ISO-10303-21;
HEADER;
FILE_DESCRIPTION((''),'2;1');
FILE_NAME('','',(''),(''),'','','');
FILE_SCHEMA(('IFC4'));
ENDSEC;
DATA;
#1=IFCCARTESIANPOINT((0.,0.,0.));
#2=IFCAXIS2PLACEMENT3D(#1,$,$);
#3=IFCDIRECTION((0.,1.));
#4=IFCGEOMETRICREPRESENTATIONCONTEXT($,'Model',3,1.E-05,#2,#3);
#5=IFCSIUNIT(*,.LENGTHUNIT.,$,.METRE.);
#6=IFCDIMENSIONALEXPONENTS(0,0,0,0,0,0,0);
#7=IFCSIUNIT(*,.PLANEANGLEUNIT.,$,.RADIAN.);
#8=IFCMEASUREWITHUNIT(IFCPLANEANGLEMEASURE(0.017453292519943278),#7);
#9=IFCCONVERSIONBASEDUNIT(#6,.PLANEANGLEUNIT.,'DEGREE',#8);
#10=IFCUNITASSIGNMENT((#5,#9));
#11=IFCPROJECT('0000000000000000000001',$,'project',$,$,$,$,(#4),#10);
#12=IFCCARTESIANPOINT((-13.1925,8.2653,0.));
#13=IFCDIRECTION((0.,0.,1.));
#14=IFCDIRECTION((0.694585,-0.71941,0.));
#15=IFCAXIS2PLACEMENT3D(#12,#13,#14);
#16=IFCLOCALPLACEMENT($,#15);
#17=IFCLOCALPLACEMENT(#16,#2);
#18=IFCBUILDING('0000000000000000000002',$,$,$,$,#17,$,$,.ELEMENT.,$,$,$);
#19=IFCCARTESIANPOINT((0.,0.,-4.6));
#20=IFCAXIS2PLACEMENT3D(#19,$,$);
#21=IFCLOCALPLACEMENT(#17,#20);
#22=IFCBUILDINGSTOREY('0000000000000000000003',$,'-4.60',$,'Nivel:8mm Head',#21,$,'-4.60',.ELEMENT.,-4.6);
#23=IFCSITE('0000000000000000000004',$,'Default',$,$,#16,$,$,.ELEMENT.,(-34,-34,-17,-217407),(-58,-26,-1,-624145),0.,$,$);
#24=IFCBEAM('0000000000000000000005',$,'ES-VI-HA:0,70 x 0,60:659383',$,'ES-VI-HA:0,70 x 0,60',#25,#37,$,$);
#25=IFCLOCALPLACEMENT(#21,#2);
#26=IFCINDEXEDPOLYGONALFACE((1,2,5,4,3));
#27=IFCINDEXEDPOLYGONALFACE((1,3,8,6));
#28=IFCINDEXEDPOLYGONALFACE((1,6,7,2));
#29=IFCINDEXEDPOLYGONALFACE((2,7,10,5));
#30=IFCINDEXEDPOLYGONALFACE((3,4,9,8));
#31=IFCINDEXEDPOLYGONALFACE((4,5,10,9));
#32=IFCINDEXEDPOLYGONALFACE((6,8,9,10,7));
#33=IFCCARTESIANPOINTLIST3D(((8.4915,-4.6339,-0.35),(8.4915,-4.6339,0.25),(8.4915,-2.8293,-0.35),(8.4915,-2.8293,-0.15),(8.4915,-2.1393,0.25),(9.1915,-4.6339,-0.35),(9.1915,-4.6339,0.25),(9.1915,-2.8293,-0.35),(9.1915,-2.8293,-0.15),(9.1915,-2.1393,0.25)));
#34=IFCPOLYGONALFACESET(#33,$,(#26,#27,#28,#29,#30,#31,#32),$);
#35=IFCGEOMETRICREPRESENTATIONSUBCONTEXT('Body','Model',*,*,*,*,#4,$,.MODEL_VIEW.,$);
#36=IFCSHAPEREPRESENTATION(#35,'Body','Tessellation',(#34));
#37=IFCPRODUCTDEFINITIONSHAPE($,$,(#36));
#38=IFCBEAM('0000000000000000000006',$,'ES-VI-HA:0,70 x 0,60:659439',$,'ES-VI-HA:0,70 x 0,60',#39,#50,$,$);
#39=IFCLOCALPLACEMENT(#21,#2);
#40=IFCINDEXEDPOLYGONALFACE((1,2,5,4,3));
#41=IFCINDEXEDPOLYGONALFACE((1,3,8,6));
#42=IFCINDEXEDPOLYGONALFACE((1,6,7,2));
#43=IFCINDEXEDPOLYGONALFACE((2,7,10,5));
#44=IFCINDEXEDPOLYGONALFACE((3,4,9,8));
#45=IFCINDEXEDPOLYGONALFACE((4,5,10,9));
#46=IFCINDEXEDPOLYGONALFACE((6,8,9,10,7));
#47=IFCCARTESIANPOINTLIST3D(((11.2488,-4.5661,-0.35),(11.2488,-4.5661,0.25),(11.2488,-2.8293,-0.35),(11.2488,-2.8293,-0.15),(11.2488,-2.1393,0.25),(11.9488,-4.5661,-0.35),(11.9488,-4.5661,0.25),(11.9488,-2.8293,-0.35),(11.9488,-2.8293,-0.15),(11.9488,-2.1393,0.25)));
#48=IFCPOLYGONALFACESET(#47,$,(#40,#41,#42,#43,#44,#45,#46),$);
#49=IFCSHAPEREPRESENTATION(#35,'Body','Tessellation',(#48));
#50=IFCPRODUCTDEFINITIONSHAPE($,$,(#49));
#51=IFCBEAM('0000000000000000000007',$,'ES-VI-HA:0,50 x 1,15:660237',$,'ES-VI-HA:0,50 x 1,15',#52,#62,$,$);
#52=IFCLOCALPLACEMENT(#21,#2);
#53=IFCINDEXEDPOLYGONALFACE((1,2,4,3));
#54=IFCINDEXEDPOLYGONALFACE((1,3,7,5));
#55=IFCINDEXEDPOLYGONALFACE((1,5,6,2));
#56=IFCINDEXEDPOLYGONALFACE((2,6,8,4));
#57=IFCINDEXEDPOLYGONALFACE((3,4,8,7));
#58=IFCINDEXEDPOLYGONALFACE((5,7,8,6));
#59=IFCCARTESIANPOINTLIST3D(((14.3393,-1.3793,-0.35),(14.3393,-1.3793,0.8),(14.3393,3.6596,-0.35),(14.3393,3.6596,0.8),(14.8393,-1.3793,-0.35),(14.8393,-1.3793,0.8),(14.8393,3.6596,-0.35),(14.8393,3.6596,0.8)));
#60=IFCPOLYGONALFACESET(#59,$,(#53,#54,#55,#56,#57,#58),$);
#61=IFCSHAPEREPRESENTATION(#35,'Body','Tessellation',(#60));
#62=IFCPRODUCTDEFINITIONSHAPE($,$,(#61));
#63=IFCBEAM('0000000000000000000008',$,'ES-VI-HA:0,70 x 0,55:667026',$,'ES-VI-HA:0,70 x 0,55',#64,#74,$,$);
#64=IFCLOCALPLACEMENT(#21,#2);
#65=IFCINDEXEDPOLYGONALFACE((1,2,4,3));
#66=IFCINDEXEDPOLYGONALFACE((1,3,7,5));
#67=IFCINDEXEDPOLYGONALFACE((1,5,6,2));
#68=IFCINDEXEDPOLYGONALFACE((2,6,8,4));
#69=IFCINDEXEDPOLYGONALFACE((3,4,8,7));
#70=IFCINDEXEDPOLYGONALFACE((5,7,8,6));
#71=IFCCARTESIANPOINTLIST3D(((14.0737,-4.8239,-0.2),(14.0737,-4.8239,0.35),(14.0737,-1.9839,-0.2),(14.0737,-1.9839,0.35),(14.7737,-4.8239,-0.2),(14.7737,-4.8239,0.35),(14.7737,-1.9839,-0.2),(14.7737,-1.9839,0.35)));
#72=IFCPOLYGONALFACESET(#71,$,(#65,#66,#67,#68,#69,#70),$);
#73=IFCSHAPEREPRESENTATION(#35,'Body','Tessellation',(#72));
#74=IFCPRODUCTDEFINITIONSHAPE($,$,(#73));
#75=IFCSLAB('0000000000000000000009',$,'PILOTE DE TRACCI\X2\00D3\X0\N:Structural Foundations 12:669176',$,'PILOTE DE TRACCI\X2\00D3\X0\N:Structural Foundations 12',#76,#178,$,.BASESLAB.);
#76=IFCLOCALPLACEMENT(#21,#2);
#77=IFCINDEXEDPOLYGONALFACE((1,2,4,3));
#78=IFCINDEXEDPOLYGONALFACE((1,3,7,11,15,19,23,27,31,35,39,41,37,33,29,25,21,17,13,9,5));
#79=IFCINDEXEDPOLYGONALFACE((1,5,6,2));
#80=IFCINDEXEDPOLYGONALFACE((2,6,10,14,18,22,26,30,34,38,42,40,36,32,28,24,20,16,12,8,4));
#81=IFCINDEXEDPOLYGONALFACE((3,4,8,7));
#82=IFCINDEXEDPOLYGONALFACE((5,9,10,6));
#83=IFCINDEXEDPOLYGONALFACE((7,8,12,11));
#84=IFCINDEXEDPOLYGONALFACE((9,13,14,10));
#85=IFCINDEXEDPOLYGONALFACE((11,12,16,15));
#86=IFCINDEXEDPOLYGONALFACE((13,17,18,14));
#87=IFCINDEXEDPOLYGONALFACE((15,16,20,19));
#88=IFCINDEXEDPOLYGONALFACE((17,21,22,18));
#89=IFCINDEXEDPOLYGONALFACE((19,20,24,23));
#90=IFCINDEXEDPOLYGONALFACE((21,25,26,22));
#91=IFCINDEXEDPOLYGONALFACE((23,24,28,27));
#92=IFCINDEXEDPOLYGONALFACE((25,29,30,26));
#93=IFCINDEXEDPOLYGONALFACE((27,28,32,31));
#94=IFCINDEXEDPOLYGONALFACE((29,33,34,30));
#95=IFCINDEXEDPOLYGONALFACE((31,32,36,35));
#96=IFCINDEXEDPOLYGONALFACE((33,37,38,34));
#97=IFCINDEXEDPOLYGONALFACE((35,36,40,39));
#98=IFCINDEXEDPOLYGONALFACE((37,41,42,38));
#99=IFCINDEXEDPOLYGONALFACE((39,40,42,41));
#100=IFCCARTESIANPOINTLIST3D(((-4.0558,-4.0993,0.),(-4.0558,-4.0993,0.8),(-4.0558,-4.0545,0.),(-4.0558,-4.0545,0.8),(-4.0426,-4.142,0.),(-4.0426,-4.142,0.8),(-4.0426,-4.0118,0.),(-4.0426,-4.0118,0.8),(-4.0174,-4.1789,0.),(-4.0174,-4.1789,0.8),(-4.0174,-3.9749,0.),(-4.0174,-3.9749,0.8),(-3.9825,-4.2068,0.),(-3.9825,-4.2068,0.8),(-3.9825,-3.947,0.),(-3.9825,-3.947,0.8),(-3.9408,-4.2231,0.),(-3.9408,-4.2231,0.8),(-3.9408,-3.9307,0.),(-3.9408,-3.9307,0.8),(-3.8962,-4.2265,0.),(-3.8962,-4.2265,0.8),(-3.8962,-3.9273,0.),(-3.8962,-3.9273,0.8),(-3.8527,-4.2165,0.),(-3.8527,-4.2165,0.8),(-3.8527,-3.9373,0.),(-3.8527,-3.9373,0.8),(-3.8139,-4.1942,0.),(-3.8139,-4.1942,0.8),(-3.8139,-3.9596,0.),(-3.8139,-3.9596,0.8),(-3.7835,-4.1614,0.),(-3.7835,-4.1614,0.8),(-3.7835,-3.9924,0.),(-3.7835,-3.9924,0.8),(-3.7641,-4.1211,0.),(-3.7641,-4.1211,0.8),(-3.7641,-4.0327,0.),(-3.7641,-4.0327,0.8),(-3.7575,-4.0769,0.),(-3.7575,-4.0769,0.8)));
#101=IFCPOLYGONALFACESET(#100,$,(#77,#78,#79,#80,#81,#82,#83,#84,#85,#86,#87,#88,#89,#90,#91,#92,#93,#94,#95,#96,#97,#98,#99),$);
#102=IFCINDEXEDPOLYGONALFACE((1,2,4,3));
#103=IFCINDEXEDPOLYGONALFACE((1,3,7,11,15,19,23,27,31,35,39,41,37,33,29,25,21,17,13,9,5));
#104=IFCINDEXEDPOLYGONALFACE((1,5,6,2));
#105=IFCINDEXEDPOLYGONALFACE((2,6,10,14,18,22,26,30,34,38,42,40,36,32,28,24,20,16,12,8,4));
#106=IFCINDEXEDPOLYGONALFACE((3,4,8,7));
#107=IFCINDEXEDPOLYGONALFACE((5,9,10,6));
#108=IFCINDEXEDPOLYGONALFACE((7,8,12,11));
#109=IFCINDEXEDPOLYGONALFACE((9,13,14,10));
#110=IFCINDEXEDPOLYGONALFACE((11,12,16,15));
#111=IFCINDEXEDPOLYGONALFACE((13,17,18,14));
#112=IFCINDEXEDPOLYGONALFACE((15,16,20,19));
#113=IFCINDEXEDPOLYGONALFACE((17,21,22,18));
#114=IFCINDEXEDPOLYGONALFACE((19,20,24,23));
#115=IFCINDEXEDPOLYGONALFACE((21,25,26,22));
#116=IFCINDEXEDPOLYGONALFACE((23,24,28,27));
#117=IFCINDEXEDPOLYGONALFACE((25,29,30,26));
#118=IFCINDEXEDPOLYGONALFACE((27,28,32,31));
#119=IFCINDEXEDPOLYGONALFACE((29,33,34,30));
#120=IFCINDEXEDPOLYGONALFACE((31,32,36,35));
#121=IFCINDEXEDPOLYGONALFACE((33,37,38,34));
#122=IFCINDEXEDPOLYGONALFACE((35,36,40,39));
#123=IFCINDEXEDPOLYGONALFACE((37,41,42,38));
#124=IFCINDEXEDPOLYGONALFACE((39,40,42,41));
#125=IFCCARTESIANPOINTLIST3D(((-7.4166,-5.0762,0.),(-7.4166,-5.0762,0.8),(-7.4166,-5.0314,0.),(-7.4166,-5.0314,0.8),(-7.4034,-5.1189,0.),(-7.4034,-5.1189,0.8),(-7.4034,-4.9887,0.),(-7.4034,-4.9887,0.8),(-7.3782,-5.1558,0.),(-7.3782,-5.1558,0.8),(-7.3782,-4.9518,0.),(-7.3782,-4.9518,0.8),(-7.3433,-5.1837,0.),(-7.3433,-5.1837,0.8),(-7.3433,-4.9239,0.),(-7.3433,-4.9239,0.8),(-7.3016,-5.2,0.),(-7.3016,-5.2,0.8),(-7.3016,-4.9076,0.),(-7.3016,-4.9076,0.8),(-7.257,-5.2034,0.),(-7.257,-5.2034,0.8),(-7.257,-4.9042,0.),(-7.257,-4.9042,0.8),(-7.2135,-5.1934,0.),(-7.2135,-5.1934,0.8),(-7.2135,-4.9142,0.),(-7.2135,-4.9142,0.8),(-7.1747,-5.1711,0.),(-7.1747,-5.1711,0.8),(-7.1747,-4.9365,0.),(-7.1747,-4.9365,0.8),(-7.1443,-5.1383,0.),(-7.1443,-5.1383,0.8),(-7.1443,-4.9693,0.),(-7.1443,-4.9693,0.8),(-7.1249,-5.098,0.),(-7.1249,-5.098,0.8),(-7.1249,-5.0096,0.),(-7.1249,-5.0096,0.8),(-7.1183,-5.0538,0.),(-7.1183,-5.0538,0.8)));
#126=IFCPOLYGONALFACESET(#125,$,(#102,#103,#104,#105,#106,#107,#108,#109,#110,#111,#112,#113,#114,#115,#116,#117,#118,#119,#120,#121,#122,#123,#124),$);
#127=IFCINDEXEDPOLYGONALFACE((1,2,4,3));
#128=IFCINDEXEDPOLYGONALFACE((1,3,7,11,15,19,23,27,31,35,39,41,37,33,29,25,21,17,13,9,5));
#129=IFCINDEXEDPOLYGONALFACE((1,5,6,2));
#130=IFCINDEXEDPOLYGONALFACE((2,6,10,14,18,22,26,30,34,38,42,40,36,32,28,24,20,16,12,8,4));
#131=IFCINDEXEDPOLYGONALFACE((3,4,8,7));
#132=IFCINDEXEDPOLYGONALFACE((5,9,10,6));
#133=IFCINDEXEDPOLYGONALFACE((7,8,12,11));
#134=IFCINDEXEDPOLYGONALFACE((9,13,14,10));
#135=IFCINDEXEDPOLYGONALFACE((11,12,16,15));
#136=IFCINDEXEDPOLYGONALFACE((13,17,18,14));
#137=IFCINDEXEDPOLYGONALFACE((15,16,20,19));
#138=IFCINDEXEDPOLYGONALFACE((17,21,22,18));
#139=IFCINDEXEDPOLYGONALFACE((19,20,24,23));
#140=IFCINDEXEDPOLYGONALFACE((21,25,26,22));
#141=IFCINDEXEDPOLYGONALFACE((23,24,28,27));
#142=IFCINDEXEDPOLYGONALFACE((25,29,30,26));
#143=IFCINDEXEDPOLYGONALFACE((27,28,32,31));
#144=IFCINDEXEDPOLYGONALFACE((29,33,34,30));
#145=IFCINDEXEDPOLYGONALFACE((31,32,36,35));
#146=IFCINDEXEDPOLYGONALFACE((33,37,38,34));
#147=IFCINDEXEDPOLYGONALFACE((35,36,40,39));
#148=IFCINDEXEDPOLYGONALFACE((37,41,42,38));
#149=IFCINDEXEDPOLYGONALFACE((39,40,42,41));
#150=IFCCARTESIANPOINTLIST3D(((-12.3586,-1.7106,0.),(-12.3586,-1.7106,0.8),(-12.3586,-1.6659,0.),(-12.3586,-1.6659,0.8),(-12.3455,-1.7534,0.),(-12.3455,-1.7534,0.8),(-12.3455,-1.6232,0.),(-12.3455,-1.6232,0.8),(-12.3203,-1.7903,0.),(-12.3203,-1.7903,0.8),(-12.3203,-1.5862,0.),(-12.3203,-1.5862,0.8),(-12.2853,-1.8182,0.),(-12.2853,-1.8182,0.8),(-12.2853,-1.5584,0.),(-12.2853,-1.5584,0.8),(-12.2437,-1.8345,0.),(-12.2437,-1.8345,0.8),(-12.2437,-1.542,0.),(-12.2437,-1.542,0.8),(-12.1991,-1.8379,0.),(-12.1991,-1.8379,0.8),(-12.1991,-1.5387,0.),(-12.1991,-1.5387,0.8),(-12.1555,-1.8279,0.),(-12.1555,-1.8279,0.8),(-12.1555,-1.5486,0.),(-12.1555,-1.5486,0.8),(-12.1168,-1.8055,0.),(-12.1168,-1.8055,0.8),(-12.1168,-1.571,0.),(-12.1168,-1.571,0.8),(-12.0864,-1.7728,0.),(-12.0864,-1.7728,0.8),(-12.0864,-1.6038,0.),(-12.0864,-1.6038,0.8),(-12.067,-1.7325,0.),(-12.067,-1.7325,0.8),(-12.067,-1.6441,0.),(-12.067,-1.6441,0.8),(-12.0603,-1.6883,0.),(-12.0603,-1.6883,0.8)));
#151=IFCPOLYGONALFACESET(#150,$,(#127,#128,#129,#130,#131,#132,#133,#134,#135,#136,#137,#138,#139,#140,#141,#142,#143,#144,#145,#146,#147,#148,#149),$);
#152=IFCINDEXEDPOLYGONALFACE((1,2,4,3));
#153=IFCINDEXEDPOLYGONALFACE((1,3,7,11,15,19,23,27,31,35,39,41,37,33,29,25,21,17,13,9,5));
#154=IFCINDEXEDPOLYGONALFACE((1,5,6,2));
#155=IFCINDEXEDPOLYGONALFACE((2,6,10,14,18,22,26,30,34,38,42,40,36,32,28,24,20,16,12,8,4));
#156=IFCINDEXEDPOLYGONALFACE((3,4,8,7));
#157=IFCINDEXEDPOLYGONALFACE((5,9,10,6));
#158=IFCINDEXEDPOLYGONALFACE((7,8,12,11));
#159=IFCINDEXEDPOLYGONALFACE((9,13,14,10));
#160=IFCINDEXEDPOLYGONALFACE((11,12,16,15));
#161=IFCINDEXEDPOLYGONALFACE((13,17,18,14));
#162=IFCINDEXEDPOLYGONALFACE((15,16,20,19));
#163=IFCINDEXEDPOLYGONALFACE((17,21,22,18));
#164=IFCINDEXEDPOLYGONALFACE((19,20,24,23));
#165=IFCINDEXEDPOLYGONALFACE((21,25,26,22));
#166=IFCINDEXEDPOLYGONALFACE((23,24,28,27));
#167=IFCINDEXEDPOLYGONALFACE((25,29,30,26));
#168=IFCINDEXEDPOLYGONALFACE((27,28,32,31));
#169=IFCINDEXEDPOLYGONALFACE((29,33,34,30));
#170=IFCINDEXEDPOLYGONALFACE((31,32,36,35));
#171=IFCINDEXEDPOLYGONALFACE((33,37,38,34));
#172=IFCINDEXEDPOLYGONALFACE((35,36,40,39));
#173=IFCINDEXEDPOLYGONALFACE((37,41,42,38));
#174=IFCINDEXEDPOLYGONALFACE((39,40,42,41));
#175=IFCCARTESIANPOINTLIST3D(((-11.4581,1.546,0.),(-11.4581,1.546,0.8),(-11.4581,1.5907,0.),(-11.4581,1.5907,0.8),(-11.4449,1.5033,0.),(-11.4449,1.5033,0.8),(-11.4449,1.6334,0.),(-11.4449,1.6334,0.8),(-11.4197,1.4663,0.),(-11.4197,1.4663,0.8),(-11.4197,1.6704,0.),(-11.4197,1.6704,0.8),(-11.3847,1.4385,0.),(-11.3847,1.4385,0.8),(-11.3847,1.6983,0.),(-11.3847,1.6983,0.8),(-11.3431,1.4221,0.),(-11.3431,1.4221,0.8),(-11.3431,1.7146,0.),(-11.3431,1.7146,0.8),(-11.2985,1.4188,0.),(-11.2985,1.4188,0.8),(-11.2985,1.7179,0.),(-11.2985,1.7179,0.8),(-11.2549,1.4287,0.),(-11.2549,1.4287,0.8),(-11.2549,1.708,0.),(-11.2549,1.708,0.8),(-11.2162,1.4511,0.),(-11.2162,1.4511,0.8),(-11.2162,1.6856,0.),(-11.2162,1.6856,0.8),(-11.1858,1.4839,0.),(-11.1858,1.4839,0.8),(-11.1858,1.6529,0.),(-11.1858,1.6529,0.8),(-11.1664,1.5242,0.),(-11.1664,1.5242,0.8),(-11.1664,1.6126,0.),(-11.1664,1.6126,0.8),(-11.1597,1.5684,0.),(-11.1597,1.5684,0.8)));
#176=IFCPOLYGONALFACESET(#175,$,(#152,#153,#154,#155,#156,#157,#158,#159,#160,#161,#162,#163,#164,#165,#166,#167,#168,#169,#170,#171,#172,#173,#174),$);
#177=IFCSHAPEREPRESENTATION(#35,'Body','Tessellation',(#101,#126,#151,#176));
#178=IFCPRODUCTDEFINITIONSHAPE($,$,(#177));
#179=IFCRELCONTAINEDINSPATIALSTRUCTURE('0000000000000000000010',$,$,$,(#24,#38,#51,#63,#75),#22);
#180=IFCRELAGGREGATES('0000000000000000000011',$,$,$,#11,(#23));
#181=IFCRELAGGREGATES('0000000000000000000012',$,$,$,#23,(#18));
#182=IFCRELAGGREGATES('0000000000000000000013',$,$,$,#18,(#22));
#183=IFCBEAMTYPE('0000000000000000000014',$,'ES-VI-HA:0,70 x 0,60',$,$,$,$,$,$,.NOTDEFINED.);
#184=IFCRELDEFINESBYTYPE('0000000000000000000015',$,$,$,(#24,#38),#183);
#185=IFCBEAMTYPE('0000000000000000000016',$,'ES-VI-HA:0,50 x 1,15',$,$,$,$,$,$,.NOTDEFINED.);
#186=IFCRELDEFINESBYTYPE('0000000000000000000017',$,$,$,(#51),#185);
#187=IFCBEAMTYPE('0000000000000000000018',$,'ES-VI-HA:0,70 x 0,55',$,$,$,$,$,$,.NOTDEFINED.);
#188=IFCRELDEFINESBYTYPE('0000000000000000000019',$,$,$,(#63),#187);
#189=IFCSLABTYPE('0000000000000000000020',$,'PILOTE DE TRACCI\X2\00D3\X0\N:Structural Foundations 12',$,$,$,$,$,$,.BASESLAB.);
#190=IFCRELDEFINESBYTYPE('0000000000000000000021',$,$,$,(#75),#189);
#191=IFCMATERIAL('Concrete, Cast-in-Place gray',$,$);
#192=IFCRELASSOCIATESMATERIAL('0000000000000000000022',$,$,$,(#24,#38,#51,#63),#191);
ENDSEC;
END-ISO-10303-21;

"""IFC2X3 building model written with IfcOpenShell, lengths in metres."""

from ifc_helpers import new_model, entity, si_unit, converted_unit, direction, frame, frame_2d, origin, origin_2d_with_axis, place, context, subcontext, project, spatial, polyline, rectangle, circle, extrude, clip, bounded_halfspace, material, type_object, element, save


model = new_model("IFC2X3")

# Units and contexts
model_context = context("Model", 3, precision=1e-05, world=origin(), true_north=direction((0.0, 1.0)))
body_context = subcontext(model_context, "Body", "Model", "MODEL_VIEW")
ifc_project = project(units=[si_unit("LENGTHUNIT", "METRE"), converted_unit("PLANEANGLEUNIT", "DEGREE", entity("IfcPlaneAngleMeasure", 0.017453292519943278), si_unit("PLANEANGLEUNIT", "RADIAN"), dimensions=[0, 0, 0, 0, 0, 0, 0])], contexts=[model_context])

# Site, building, storey
site_placement = place(None, frame((-13.1925, 8.2653, 0.0), z_axis=(0.0, 0.0, 1.0), x_axis=(0.694585, -0.71941, 0.0)))
site = spatial("IfcSite", under=ifc_project, at=site_placement, Name="Default", CompositionType="ELEMENT", RefLatitude=(-34, -34, -17, -217407), RefLongitude=(-58, -26, -1, -624145), RefElevation=0.0)
building_placement = place(site_placement, origin())
building = spatial("IfcBuilding", under=site, at=building_placement, CompositionType="ELEMENT")
storey_placement = place(building_placement, frame((0.0, 0.0, -4.6)))
storey = spatial("IfcBuildingStorey", under=building, at=storey_placement, Name="-4.60", ObjectType="Nivel:8mm Head", LongName="-4.60", CompositionType="ELEMENT", Elevation=-4.6)

# Beams
ifc_material_1 = material(Name="Concrete, Cast-in-Place gray")
beam_type_1 = type_object("IfcBeamType", Name="ES-VI-HA:0,70 x 0,60", PredefinedType="NOTDEFINED")
beam_1_placement = place(storey_placement, frame((8.8415, -1.5401, 0.25), z_axis=(0.0, 0.0, 1.0), x_axis=(0.0, -1.0, 0.0)))
element("IfcBeam", 1, at=beam_1_placement, inside=storey, type_object=beam_type_1, material=ifc_material_1, Name="ES-VI-HA:0,70 x 0,60:659383", ObjectType="ES-VI-HA:0,70 x 0,60", context=body_context, shape_type="SweptSolid", body=[
    clip(clip(extrude(rectangle(XDim=0.6, YDim=0.7, at=frame_2d((0.0, 0.0), x_axis=(0.0, 1.0))), frame((0.5991, 0.0, -0.3), z_axis=(1.0, 0.0, 0.0), x_axis=(0.0, 1.0, 0.0)), (0.0, 0.0, 1.0), 2.4947), bounded_halfspace(frame((1.2891, 0.1748, -0.4), z_axis=(-0.50153, 0.0, -0.86514), x_axis=(0.0, 1.0, 0.0)), False, frame((0.5991, 0.0, -0.3), z_axis=(1.0, 0.0, 0.0), x_axis=(0.0, 1.0, 0.0)), polyline([(0.35, -0.1), (-0.35, -0.1), (-0.35, 0.3), (0.35, 0.3), (0.35, -0.1)]))), bounded_halfspace(frame((1.2891, -0.9752, -0.4), z_axis=(-1.0, 0.0, 0.0), x_axis=(0.0, 0.0, -1.0)), False, frame((0.5991, 0.0, -0.3), z_axis=(1.0, 0.0, 0.0), x_axis=(0.0, 1.0, 0.0)), polyline([(-0.35, -0.1), (0.35, -0.1), (0.35, -0.3), (-0.35, -0.3), (-0.35, -0.1)]))),
])
beam_2_placement = place(storey_placement, frame((11.5988, -1.8037, 0.25), z_axis=(0.0, 0.0, 1.0), x_axis=(0.0, -1.0, 0.0)))
element("IfcBeam", 2, at=beam_2_placement, inside=storey, type_object=beam_type_1, material=ifc_material_1, Name="ES-VI-HA:0,70 x 0,60:659439", ObjectType="ES-VI-HA:0,70 x 0,60", context=body_context, shape_type="SweptSolid", body=[
    clip(clip(extrude(rectangle(XDim=0.6, YDim=0.7, at=frame_2d((0.0, 0.0), x_axis=(0.0, 1.0))), frame((0.3356, 0.0, -0.3), z_axis=(1.0, 0.0, 0.0), x_axis=(0.0, 1.0, 0.0)), (0.0, 0.0, 1.0), 2.4268), bounded_halfspace(frame((1.0256, 0.0, -0.4), z_axis=(-0.50153, 0.0, -0.86514), x_axis=(0.0, 1.0, 0.0)), False, frame((0.3356, 0.0, -0.3), z_axis=(1.0, 0.0, 0.0), x_axis=(0.0, 1.0, 0.0)), polyline([(0.35, -0.1), (-0.35, -0.1), (-0.35, 0.3), (0.35, 0.3), (0.35, -0.1)]))), bounded_halfspace(frame((1.0256, -1.15, -0.4), z_axis=(-1.0, 0.0, 0.0), x_axis=(0.0, 0.0, -1.0)), False, frame((0.3356, 0.0, -0.3), z_axis=(1.0, 0.0, 0.0), x_axis=(0.0, 1.0, 0.0)), polyline([(-0.35, -0.1), (0.35, -0.1), (0.35, -0.3), (-0.35, -0.3), (-0.35, -0.1)]))),
])
beam_type_2 = type_object("IfcBeamType", Name="ES-VI-HA:0,50 x 1,15", PredefinedType="NOTDEFINED")
beam_3_placement = place(storey_placement, frame((14.5893, -1.5939, 0.8), z_axis=(0.0, 0.0, 1.0), x_axis=(0.0, 1.0, 0.0)))
element("IfcBeam", 3, at=beam_3_placement, inside=storey, type_object=beam_type_2, material=ifc_material_1, Name="ES-VI-HA:0,50 x 1,15:660237", ObjectType="ES-VI-HA:0,50 x 1,15", context=body_context, shape_type="SweptSolid", body=[
    extrude(rectangle(XDim=1.15, YDim=0.5, at=frame_2d((0.0, 0.0), x_axis=(1.0, 0.0))), frame((0.2146, 0.0, -0.575), z_axis=(1.0, 0.0, 0.0), x_axis=(0.0, 0.0, -1.0)), (0.0, 0.0, 1.0), 5.039),
])
beam_type_3 = type_object("IfcBeamType", Name="ES-VI-HA:0,70 x 0,55", PredefinedType="NOTDEFINED")
beam_4_placement = place(storey_placement, frame((14.4237, -1.9839, 0.35), z_axis=(0.0, 0.0, 1.0), x_axis=(0.0, -1.0, 0.0)))
element("IfcBeam", 4, at=beam_4_placement, inside=storey, type_object=beam_type_3, material=ifc_material_1, Name="ES-VI-HA:0,70 x 0,55:667026", ObjectType="ES-VI-HA:0,70 x 0,55", context=body_context, shape_type="SweptSolid", body=[
    extrude(rectangle(XDim=0.55, YDim=0.7, at=frame_2d((0.0, 0.0), x_axis=(1.0, 0.0))), frame((0.0, 0.0, -0.275), z_axis=(1.0, 0.0, 0.0), x_axis=(0.0, 0.0, -1.0)), (0.0, 0.0, 1.0), 2.84),
])

# Slab
slab_type_1 = type_object("IfcSlabType", Name="PILOTE DE TRACCIÓN:Structural Foundations 12", PredefinedType="BASESLAB")
slab_1_placement = place(storey_placement, origin())
element("IfcSlab", 5, at=slab_1_placement, inside=storey, type_object=slab_type_1, Name="PILOTE DE TRACCIÓN:Structural Foundations 12:669176", ObjectType="PILOTE DE TRACCIÓN:Structural Foundations 12", PredefinedType="BASESLAB", context=body_context, shape_type="SweptSolid", body=[
    extrude(circle(Radius=0.15, at=origin_2d_with_axis()), frame((-3.9075, -4.0769, 0.0)), (0.0, 0.0, 1.0), 0.8),
    extrude(circle(Radius=0.15, at=origin_2d_with_axis()), frame((-7.2683, -5.0538, 0.0)), (0.0, 0.0, 1.0), 0.8),
    extrude(circle(Radius=0.15, at=frame_2d((0.0, 0.0), x_axis=(1.0, 0.0))), frame((-12.2103, -1.6883, 0.0)), (0.0, 0.0, 1.0), 0.8),
    extrude(circle(Radius=0.15, at=frame_2d((0.0, 0.0), x_axis=(1.0, 0.0))), frame((-11.3097, 1.5684, 0.0)), (0.0, 0.0, 1.0), 0.8),
])

save(model, "model.ifc")
